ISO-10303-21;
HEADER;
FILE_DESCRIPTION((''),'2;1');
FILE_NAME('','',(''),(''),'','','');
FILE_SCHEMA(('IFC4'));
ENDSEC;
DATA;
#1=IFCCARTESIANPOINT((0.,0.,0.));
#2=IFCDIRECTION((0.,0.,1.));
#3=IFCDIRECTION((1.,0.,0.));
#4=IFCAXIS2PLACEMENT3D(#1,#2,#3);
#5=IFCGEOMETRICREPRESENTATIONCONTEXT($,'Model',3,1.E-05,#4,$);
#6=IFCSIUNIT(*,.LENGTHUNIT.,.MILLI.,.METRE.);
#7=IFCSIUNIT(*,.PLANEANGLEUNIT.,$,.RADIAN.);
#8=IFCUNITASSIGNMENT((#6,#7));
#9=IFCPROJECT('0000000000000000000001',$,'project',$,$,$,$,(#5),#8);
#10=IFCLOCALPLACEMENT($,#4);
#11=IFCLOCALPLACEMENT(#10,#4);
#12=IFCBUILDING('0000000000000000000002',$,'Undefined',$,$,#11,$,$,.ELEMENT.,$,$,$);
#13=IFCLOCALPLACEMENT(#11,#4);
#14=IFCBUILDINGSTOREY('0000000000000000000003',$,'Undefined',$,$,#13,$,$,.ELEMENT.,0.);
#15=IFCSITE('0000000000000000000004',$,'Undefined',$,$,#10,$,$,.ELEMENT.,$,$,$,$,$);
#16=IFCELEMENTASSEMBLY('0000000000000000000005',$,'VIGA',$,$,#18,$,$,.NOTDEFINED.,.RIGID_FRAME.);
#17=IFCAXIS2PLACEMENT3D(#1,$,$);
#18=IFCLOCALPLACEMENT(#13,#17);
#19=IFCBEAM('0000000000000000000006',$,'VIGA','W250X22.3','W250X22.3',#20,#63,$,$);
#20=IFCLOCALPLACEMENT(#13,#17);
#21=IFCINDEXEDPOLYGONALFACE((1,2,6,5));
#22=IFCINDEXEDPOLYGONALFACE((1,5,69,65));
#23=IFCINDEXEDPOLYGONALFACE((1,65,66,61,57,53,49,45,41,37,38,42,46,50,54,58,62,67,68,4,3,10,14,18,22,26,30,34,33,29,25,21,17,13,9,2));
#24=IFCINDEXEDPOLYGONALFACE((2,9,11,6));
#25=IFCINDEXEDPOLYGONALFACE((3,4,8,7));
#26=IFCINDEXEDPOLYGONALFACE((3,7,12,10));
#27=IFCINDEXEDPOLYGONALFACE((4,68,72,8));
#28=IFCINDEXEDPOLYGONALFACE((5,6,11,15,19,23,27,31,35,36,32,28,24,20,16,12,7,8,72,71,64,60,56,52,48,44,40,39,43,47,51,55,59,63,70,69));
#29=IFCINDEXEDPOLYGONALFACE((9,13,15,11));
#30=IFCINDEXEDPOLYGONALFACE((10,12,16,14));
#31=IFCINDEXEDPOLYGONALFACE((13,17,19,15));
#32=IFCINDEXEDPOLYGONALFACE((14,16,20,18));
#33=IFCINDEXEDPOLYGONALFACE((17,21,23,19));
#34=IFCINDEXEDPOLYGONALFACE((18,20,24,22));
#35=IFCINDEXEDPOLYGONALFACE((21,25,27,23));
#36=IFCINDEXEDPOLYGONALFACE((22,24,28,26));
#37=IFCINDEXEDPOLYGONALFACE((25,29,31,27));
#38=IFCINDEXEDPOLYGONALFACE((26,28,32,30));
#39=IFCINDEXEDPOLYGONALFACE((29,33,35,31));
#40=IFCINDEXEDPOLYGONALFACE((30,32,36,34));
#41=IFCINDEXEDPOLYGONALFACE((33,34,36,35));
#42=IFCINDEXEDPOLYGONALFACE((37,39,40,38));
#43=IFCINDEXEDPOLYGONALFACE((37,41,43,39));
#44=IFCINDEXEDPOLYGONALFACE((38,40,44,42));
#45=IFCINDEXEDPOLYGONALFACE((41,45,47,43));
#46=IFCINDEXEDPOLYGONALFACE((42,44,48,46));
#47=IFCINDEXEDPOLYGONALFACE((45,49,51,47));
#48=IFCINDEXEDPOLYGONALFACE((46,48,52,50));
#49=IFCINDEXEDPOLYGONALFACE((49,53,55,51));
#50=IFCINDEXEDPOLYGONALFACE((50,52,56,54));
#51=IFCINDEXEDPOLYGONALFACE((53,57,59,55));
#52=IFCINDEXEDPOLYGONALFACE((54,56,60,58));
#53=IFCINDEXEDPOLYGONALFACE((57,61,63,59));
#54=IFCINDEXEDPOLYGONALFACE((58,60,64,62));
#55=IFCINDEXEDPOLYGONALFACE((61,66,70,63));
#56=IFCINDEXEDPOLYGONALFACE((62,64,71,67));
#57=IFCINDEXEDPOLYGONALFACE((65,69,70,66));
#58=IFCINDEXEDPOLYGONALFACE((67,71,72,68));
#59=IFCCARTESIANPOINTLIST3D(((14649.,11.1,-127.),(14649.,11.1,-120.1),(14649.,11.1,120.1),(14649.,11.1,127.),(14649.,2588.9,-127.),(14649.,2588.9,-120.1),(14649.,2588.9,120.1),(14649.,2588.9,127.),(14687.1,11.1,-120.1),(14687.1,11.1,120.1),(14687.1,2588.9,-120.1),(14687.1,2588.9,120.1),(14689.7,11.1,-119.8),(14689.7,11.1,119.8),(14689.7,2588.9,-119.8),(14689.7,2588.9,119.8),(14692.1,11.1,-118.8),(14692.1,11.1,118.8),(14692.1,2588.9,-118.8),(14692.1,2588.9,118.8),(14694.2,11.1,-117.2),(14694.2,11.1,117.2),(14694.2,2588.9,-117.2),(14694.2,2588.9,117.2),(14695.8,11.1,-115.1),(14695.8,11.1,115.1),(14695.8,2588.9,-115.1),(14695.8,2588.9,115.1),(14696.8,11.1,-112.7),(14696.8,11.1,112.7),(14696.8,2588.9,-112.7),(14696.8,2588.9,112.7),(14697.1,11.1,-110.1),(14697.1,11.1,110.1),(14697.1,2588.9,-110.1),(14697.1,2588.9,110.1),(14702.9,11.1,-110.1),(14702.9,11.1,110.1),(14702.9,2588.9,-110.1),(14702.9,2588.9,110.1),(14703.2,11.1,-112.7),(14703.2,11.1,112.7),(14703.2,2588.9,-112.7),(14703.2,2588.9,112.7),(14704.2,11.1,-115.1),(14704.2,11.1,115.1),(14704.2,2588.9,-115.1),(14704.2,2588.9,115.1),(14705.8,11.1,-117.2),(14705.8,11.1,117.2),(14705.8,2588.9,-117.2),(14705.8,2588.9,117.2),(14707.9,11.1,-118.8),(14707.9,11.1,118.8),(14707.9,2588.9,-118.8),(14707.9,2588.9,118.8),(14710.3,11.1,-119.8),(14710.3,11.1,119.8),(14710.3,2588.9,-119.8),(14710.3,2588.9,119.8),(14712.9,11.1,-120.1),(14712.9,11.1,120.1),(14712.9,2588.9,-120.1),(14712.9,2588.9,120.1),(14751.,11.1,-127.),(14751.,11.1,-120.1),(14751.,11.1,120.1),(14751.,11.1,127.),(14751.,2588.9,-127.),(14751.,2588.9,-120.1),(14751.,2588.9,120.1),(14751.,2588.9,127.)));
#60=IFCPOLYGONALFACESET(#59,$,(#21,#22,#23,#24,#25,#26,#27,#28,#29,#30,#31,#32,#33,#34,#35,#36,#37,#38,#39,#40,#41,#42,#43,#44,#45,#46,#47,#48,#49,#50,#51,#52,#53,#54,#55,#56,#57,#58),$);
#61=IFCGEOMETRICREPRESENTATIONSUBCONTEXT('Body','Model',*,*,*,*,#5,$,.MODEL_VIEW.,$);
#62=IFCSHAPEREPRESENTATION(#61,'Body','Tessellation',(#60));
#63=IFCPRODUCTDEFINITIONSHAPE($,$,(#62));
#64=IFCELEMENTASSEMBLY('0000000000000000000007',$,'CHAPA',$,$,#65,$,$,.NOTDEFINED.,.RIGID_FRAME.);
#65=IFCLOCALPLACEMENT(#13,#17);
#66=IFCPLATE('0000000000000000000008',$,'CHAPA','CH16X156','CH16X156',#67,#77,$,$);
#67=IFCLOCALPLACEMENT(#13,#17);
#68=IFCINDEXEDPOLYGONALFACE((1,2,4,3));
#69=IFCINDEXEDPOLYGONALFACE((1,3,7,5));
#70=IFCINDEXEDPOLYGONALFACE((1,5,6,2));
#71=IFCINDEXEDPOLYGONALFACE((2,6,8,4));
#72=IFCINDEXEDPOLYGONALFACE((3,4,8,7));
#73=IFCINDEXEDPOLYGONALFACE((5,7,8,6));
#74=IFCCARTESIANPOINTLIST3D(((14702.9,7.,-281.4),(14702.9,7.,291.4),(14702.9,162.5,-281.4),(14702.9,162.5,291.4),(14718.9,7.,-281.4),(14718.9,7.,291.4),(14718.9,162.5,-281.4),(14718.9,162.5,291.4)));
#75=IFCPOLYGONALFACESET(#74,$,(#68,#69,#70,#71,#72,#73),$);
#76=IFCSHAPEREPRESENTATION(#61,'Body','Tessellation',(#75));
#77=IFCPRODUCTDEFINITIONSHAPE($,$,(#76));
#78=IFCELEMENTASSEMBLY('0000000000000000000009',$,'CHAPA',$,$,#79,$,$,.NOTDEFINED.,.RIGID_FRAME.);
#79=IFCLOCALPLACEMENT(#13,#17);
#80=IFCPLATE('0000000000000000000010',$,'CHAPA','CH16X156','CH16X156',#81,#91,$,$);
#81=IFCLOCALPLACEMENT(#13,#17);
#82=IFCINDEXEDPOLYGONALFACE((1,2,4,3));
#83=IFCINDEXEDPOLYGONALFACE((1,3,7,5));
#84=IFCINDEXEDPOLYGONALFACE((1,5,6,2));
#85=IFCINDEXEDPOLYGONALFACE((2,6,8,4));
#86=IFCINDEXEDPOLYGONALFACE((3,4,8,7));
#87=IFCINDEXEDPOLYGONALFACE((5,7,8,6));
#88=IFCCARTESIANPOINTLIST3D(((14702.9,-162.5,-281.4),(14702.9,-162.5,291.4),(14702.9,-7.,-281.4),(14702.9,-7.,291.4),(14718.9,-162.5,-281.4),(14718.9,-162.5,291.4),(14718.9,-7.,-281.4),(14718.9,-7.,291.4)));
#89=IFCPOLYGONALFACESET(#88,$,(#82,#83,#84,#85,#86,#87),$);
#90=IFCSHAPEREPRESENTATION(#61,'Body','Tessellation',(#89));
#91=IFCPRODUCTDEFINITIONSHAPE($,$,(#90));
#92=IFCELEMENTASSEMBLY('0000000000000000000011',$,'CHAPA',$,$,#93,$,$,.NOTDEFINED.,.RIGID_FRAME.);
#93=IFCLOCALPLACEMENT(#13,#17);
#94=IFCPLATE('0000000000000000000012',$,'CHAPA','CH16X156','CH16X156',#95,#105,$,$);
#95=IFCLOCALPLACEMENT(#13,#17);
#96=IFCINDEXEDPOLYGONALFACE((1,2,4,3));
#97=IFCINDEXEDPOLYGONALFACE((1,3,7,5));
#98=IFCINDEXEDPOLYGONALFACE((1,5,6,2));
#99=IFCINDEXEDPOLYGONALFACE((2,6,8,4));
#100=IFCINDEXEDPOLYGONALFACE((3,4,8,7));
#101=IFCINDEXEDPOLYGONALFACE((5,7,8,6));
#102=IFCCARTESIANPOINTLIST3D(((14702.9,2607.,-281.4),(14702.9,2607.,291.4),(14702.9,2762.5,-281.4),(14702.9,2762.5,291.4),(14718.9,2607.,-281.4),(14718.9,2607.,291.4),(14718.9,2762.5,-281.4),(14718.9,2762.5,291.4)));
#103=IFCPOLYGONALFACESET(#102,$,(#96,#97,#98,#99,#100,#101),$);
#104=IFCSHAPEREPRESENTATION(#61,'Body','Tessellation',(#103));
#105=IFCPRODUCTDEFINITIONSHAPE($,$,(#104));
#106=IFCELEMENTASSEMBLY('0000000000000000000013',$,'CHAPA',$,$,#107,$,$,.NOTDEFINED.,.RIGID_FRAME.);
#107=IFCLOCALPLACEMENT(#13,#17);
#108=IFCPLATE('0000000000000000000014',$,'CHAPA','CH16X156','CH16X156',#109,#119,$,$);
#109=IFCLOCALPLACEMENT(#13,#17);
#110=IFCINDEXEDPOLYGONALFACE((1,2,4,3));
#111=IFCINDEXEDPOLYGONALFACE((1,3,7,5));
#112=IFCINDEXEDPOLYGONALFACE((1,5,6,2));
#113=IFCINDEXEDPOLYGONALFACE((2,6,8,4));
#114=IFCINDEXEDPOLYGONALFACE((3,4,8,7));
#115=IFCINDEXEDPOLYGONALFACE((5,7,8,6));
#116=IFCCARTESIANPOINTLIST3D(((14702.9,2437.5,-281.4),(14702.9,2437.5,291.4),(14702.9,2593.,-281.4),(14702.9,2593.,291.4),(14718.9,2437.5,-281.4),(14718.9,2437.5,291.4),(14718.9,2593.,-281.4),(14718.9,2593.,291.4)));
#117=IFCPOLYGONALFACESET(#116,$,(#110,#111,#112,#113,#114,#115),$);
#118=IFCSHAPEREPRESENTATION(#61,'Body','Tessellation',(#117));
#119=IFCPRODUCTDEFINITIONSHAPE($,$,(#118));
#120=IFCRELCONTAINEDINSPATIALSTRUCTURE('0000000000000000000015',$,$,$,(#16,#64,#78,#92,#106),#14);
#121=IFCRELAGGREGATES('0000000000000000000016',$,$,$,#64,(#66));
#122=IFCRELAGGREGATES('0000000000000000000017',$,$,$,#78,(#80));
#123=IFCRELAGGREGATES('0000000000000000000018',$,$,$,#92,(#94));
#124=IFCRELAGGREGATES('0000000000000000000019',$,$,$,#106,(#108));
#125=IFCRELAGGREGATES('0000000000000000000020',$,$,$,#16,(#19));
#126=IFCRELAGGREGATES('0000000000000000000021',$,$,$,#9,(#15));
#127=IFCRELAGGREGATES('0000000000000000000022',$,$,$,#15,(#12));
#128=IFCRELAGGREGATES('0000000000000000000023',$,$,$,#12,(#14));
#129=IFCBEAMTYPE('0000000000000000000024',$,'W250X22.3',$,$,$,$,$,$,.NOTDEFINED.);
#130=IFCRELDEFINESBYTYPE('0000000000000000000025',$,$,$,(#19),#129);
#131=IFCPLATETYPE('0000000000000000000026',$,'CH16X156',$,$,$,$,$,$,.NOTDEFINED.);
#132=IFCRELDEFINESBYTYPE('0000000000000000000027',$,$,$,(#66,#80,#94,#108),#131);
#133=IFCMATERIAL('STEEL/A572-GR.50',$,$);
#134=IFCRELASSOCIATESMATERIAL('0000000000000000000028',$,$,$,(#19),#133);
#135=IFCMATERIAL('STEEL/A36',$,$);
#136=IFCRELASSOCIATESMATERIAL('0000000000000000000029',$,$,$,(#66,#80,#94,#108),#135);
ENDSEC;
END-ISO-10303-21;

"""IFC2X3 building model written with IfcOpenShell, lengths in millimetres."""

from ifc_helpers import new_model, si_unit, frame, origin_with_axes, origin_2d_with_axis, place, context, subcontext, project, spatial, polyline, i_section, outline, extrude, material, type_object, element, aggregate, save


model = new_model("IFC2X3")

# Units and contexts
model_context = context("Model", 3, precision=1e-05, world=origin_with_axes())
body_context = subcontext(model_context, "Body", "Model", "MODEL_VIEW")
ifc_project = project(units=[si_unit("LENGTHUNIT", "METRE", prefix="MILLI"), si_unit("PLANEANGLEUNIT", "RADIAN")], contexts=[model_context])

# Site, building, storey
site_placement = place(None, origin_with_axes())
site = spatial("IfcSite", under=ifc_project, at=site_placement, Name="Undefined", CompositionType="ELEMENT")
building_placement = place(site_placement, origin_with_axes())
building = spatial("IfcBuilding", under=site, at=building_placement, Name="Undefined", CompositionType="ELEMENT")
storey_placement = place(building_placement, origin_with_axes())
storey = spatial("IfcBuildingStorey", under=building, at=storey_placement, Name="Undefined", CompositionType="ELEMENT", Elevation=0.0)

# Element assembly, beam
ifc_material_1 = material(Name="STEEL/A572-GR.50")
assembly_1_placement = place(storey_placement, origin_with_axes())
assembly_1 = element("IfcElementAssembly", 1, at=assembly_1_placement, inside=storey, Name="VIGA", AssemblyPlace="NOTDEFINED", PredefinedType="RIGID_FRAME")
beam_type_1 = type_object("IfcBeamType", Name="W250X22.3", PredefinedType="NOTDEFINED")
beam_1_placement = place(assembly_1_placement, frame((14700.0, 11.1, 0.0), z_axis=(0.0, 0.0, 1.0), x_axis=(0.0, 1.0, 0.0)))
beam_1 = element("IfcBeam", 2, at=beam_1_placement, type_object=beam_type_1, material=ifc_material_1, Name="VIGA", Description="W250X22.3", ObjectType="W250X22.3", context=body_context, shape_type="SweptSolid", body=[
    extrude(i_section(OverallWidth=102.0, OverallDepth=254.0, WebThickness=5.8, FlangeThickness=6.9, FilletRadius=10.0, at=origin_2d_with_axis()), frame((2577.8, 0.0, 0.0), z_axis=(-1.0, 0.0, 0.0), x_axis=(0.0, -1.0, 0.0)), (0.0, 0.0, 1.0), 2577.8),
])

# Element assemblies, plates
assembly_2_placement = place(storey_placement, origin_with_axes())
assembly_2 = element("IfcElementAssembly", 3, at=assembly_2_placement, inside=storey, Name="CHAPA", AssemblyPlace="NOTDEFINED", PredefinedType="RIGID_FRAME")
ifc_material_2 = material(Name="STEEL/A36")
plate_type = type_object("IfcPlateType", Name="CH16X156", PredefinedType="NOTDEFINED")
plate_1_placement = place(assembly_2_placement, frame((14710.9, 162.5, 291.4), z_axis=(1.0, 0.0, 0.0), x_axis=(0.0, -1.0, 0.0)))
plate_1 = element("IfcPlate", 4, at=plate_1_placement, type_object=plate_type, material=ifc_material_2, Name="CHAPA", Description="CH16X156", ObjectType="CH16X156", context=body_context, shape_type="SweptSolid", body=[
    extrude(outline(polyline([(0.0, 0.0), (155.5, 0.0), (155.5, 572.8), (0.0, 572.8), (0.0, 0.0)])), frame((0.0, 0.0, -8.0), z_axis=(0.0, 0.0, 1.0), x_axis=(1.0, 0.0, 0.0)), (0.0, 0.0, 1.0), 16.0),
])
aggregate(assembly_2, [plate_1])
assembly_3_placement = place(storey_placement, origin_with_axes())
assembly_3 = element("IfcElementAssembly", 5, at=assembly_3_placement, inside=storey, Name="CHAPA", AssemblyPlace="NOTDEFINED", PredefinedType="RIGID_FRAME")
plate_2_placement = place(assembly_3_placement, frame((14710.9, -7.0, 291.4), z_axis=(1.0, 0.0, 0.0), x_axis=(0.0, -1.0, 0.0)))
plate_2 = element("IfcPlate", 6, at=plate_2_placement, type_object=plate_type, material=ifc_material_2, Name="CHAPA", Description="CH16X156", ObjectType="CH16X156", context=body_context, shape_type="SweptSolid", body=[
    extrude(outline(polyline([(0.0, 0.0), (155.5, 0.0), (155.5, 572.8), (0.0, 572.8), (0.0, 0.0)])), frame((0.0, 0.0, -8.0), z_axis=(0.0, 0.0, 1.0), x_axis=(1.0, 0.0, 0.0)), (0.0, 0.0, 1.0), 16.0),
])
aggregate(assembly_3, [plate_2])
assembly_4_placement = place(storey_placement, origin_with_axes())
assembly_4 = element("IfcElementAssembly", 7, at=assembly_4_placement, inside=storey, Name="CHAPA", AssemblyPlace="NOTDEFINED", PredefinedType="RIGID_FRAME")
plate_3_placement = place(assembly_4_placement, frame((14710.9, 2762.5, 291.4), z_axis=(1.0, 0.0, 0.0), x_axis=(0.0, -1.0, 0.0)))
plate_3 = element("IfcPlate", 8, at=plate_3_placement, type_object=plate_type, material=ifc_material_2, Name="CHAPA", Description="CH16X156", ObjectType="CH16X156", context=body_context, shape_type="SweptSolid", body=[
    extrude(outline(polyline([(0.0, 0.0), (155.5, 0.0), (155.5, 572.8), (0.0, 572.8), (0.0, 0.0)])), frame((0.0, 0.0, -8.0), z_axis=(0.0, 0.0, 1.0), x_axis=(1.0, 0.0, 0.0)), (0.0, 0.0, 1.0), 16.0),
])
aggregate(assembly_4, [plate_3])
assembly_5_placement = place(storey_placement, origin_with_axes())
assembly_5 = element("IfcElementAssembly", 9, at=assembly_5_placement, inside=storey, Name="CHAPA", AssemblyPlace="NOTDEFINED", PredefinedType="RIGID_FRAME")
plate_4_placement = place(assembly_5_placement, frame((14710.9, 2593.0, 291.4), z_axis=(1.0, 0.0, 0.0), x_axis=(0.0, -1.0, 0.0)))
plate_4 = element("IfcPlate", 10, at=plate_4_placement, type_object=plate_type, material=ifc_material_2, Name="CHAPA", Description="CH16X156", ObjectType="CH16X156", context=body_context, shape_type="SweptSolid", body=[
    extrude(outline(polyline([(0.0, 0.0), (155.5, 0.0), (155.5, 572.8), (0.0, 572.8), (0.0, 0.0)])), frame((0.0, 0.0, -8.0), z_axis=(0.0, 0.0, 1.0), x_axis=(1.0, 0.0, 0.0)), (0.0, 0.0, 1.0), 16.0),
])
aggregate(assembly_5, [plate_4])

aggregate(assembly_1, [beam_1])

save(model, "model.ifc")
